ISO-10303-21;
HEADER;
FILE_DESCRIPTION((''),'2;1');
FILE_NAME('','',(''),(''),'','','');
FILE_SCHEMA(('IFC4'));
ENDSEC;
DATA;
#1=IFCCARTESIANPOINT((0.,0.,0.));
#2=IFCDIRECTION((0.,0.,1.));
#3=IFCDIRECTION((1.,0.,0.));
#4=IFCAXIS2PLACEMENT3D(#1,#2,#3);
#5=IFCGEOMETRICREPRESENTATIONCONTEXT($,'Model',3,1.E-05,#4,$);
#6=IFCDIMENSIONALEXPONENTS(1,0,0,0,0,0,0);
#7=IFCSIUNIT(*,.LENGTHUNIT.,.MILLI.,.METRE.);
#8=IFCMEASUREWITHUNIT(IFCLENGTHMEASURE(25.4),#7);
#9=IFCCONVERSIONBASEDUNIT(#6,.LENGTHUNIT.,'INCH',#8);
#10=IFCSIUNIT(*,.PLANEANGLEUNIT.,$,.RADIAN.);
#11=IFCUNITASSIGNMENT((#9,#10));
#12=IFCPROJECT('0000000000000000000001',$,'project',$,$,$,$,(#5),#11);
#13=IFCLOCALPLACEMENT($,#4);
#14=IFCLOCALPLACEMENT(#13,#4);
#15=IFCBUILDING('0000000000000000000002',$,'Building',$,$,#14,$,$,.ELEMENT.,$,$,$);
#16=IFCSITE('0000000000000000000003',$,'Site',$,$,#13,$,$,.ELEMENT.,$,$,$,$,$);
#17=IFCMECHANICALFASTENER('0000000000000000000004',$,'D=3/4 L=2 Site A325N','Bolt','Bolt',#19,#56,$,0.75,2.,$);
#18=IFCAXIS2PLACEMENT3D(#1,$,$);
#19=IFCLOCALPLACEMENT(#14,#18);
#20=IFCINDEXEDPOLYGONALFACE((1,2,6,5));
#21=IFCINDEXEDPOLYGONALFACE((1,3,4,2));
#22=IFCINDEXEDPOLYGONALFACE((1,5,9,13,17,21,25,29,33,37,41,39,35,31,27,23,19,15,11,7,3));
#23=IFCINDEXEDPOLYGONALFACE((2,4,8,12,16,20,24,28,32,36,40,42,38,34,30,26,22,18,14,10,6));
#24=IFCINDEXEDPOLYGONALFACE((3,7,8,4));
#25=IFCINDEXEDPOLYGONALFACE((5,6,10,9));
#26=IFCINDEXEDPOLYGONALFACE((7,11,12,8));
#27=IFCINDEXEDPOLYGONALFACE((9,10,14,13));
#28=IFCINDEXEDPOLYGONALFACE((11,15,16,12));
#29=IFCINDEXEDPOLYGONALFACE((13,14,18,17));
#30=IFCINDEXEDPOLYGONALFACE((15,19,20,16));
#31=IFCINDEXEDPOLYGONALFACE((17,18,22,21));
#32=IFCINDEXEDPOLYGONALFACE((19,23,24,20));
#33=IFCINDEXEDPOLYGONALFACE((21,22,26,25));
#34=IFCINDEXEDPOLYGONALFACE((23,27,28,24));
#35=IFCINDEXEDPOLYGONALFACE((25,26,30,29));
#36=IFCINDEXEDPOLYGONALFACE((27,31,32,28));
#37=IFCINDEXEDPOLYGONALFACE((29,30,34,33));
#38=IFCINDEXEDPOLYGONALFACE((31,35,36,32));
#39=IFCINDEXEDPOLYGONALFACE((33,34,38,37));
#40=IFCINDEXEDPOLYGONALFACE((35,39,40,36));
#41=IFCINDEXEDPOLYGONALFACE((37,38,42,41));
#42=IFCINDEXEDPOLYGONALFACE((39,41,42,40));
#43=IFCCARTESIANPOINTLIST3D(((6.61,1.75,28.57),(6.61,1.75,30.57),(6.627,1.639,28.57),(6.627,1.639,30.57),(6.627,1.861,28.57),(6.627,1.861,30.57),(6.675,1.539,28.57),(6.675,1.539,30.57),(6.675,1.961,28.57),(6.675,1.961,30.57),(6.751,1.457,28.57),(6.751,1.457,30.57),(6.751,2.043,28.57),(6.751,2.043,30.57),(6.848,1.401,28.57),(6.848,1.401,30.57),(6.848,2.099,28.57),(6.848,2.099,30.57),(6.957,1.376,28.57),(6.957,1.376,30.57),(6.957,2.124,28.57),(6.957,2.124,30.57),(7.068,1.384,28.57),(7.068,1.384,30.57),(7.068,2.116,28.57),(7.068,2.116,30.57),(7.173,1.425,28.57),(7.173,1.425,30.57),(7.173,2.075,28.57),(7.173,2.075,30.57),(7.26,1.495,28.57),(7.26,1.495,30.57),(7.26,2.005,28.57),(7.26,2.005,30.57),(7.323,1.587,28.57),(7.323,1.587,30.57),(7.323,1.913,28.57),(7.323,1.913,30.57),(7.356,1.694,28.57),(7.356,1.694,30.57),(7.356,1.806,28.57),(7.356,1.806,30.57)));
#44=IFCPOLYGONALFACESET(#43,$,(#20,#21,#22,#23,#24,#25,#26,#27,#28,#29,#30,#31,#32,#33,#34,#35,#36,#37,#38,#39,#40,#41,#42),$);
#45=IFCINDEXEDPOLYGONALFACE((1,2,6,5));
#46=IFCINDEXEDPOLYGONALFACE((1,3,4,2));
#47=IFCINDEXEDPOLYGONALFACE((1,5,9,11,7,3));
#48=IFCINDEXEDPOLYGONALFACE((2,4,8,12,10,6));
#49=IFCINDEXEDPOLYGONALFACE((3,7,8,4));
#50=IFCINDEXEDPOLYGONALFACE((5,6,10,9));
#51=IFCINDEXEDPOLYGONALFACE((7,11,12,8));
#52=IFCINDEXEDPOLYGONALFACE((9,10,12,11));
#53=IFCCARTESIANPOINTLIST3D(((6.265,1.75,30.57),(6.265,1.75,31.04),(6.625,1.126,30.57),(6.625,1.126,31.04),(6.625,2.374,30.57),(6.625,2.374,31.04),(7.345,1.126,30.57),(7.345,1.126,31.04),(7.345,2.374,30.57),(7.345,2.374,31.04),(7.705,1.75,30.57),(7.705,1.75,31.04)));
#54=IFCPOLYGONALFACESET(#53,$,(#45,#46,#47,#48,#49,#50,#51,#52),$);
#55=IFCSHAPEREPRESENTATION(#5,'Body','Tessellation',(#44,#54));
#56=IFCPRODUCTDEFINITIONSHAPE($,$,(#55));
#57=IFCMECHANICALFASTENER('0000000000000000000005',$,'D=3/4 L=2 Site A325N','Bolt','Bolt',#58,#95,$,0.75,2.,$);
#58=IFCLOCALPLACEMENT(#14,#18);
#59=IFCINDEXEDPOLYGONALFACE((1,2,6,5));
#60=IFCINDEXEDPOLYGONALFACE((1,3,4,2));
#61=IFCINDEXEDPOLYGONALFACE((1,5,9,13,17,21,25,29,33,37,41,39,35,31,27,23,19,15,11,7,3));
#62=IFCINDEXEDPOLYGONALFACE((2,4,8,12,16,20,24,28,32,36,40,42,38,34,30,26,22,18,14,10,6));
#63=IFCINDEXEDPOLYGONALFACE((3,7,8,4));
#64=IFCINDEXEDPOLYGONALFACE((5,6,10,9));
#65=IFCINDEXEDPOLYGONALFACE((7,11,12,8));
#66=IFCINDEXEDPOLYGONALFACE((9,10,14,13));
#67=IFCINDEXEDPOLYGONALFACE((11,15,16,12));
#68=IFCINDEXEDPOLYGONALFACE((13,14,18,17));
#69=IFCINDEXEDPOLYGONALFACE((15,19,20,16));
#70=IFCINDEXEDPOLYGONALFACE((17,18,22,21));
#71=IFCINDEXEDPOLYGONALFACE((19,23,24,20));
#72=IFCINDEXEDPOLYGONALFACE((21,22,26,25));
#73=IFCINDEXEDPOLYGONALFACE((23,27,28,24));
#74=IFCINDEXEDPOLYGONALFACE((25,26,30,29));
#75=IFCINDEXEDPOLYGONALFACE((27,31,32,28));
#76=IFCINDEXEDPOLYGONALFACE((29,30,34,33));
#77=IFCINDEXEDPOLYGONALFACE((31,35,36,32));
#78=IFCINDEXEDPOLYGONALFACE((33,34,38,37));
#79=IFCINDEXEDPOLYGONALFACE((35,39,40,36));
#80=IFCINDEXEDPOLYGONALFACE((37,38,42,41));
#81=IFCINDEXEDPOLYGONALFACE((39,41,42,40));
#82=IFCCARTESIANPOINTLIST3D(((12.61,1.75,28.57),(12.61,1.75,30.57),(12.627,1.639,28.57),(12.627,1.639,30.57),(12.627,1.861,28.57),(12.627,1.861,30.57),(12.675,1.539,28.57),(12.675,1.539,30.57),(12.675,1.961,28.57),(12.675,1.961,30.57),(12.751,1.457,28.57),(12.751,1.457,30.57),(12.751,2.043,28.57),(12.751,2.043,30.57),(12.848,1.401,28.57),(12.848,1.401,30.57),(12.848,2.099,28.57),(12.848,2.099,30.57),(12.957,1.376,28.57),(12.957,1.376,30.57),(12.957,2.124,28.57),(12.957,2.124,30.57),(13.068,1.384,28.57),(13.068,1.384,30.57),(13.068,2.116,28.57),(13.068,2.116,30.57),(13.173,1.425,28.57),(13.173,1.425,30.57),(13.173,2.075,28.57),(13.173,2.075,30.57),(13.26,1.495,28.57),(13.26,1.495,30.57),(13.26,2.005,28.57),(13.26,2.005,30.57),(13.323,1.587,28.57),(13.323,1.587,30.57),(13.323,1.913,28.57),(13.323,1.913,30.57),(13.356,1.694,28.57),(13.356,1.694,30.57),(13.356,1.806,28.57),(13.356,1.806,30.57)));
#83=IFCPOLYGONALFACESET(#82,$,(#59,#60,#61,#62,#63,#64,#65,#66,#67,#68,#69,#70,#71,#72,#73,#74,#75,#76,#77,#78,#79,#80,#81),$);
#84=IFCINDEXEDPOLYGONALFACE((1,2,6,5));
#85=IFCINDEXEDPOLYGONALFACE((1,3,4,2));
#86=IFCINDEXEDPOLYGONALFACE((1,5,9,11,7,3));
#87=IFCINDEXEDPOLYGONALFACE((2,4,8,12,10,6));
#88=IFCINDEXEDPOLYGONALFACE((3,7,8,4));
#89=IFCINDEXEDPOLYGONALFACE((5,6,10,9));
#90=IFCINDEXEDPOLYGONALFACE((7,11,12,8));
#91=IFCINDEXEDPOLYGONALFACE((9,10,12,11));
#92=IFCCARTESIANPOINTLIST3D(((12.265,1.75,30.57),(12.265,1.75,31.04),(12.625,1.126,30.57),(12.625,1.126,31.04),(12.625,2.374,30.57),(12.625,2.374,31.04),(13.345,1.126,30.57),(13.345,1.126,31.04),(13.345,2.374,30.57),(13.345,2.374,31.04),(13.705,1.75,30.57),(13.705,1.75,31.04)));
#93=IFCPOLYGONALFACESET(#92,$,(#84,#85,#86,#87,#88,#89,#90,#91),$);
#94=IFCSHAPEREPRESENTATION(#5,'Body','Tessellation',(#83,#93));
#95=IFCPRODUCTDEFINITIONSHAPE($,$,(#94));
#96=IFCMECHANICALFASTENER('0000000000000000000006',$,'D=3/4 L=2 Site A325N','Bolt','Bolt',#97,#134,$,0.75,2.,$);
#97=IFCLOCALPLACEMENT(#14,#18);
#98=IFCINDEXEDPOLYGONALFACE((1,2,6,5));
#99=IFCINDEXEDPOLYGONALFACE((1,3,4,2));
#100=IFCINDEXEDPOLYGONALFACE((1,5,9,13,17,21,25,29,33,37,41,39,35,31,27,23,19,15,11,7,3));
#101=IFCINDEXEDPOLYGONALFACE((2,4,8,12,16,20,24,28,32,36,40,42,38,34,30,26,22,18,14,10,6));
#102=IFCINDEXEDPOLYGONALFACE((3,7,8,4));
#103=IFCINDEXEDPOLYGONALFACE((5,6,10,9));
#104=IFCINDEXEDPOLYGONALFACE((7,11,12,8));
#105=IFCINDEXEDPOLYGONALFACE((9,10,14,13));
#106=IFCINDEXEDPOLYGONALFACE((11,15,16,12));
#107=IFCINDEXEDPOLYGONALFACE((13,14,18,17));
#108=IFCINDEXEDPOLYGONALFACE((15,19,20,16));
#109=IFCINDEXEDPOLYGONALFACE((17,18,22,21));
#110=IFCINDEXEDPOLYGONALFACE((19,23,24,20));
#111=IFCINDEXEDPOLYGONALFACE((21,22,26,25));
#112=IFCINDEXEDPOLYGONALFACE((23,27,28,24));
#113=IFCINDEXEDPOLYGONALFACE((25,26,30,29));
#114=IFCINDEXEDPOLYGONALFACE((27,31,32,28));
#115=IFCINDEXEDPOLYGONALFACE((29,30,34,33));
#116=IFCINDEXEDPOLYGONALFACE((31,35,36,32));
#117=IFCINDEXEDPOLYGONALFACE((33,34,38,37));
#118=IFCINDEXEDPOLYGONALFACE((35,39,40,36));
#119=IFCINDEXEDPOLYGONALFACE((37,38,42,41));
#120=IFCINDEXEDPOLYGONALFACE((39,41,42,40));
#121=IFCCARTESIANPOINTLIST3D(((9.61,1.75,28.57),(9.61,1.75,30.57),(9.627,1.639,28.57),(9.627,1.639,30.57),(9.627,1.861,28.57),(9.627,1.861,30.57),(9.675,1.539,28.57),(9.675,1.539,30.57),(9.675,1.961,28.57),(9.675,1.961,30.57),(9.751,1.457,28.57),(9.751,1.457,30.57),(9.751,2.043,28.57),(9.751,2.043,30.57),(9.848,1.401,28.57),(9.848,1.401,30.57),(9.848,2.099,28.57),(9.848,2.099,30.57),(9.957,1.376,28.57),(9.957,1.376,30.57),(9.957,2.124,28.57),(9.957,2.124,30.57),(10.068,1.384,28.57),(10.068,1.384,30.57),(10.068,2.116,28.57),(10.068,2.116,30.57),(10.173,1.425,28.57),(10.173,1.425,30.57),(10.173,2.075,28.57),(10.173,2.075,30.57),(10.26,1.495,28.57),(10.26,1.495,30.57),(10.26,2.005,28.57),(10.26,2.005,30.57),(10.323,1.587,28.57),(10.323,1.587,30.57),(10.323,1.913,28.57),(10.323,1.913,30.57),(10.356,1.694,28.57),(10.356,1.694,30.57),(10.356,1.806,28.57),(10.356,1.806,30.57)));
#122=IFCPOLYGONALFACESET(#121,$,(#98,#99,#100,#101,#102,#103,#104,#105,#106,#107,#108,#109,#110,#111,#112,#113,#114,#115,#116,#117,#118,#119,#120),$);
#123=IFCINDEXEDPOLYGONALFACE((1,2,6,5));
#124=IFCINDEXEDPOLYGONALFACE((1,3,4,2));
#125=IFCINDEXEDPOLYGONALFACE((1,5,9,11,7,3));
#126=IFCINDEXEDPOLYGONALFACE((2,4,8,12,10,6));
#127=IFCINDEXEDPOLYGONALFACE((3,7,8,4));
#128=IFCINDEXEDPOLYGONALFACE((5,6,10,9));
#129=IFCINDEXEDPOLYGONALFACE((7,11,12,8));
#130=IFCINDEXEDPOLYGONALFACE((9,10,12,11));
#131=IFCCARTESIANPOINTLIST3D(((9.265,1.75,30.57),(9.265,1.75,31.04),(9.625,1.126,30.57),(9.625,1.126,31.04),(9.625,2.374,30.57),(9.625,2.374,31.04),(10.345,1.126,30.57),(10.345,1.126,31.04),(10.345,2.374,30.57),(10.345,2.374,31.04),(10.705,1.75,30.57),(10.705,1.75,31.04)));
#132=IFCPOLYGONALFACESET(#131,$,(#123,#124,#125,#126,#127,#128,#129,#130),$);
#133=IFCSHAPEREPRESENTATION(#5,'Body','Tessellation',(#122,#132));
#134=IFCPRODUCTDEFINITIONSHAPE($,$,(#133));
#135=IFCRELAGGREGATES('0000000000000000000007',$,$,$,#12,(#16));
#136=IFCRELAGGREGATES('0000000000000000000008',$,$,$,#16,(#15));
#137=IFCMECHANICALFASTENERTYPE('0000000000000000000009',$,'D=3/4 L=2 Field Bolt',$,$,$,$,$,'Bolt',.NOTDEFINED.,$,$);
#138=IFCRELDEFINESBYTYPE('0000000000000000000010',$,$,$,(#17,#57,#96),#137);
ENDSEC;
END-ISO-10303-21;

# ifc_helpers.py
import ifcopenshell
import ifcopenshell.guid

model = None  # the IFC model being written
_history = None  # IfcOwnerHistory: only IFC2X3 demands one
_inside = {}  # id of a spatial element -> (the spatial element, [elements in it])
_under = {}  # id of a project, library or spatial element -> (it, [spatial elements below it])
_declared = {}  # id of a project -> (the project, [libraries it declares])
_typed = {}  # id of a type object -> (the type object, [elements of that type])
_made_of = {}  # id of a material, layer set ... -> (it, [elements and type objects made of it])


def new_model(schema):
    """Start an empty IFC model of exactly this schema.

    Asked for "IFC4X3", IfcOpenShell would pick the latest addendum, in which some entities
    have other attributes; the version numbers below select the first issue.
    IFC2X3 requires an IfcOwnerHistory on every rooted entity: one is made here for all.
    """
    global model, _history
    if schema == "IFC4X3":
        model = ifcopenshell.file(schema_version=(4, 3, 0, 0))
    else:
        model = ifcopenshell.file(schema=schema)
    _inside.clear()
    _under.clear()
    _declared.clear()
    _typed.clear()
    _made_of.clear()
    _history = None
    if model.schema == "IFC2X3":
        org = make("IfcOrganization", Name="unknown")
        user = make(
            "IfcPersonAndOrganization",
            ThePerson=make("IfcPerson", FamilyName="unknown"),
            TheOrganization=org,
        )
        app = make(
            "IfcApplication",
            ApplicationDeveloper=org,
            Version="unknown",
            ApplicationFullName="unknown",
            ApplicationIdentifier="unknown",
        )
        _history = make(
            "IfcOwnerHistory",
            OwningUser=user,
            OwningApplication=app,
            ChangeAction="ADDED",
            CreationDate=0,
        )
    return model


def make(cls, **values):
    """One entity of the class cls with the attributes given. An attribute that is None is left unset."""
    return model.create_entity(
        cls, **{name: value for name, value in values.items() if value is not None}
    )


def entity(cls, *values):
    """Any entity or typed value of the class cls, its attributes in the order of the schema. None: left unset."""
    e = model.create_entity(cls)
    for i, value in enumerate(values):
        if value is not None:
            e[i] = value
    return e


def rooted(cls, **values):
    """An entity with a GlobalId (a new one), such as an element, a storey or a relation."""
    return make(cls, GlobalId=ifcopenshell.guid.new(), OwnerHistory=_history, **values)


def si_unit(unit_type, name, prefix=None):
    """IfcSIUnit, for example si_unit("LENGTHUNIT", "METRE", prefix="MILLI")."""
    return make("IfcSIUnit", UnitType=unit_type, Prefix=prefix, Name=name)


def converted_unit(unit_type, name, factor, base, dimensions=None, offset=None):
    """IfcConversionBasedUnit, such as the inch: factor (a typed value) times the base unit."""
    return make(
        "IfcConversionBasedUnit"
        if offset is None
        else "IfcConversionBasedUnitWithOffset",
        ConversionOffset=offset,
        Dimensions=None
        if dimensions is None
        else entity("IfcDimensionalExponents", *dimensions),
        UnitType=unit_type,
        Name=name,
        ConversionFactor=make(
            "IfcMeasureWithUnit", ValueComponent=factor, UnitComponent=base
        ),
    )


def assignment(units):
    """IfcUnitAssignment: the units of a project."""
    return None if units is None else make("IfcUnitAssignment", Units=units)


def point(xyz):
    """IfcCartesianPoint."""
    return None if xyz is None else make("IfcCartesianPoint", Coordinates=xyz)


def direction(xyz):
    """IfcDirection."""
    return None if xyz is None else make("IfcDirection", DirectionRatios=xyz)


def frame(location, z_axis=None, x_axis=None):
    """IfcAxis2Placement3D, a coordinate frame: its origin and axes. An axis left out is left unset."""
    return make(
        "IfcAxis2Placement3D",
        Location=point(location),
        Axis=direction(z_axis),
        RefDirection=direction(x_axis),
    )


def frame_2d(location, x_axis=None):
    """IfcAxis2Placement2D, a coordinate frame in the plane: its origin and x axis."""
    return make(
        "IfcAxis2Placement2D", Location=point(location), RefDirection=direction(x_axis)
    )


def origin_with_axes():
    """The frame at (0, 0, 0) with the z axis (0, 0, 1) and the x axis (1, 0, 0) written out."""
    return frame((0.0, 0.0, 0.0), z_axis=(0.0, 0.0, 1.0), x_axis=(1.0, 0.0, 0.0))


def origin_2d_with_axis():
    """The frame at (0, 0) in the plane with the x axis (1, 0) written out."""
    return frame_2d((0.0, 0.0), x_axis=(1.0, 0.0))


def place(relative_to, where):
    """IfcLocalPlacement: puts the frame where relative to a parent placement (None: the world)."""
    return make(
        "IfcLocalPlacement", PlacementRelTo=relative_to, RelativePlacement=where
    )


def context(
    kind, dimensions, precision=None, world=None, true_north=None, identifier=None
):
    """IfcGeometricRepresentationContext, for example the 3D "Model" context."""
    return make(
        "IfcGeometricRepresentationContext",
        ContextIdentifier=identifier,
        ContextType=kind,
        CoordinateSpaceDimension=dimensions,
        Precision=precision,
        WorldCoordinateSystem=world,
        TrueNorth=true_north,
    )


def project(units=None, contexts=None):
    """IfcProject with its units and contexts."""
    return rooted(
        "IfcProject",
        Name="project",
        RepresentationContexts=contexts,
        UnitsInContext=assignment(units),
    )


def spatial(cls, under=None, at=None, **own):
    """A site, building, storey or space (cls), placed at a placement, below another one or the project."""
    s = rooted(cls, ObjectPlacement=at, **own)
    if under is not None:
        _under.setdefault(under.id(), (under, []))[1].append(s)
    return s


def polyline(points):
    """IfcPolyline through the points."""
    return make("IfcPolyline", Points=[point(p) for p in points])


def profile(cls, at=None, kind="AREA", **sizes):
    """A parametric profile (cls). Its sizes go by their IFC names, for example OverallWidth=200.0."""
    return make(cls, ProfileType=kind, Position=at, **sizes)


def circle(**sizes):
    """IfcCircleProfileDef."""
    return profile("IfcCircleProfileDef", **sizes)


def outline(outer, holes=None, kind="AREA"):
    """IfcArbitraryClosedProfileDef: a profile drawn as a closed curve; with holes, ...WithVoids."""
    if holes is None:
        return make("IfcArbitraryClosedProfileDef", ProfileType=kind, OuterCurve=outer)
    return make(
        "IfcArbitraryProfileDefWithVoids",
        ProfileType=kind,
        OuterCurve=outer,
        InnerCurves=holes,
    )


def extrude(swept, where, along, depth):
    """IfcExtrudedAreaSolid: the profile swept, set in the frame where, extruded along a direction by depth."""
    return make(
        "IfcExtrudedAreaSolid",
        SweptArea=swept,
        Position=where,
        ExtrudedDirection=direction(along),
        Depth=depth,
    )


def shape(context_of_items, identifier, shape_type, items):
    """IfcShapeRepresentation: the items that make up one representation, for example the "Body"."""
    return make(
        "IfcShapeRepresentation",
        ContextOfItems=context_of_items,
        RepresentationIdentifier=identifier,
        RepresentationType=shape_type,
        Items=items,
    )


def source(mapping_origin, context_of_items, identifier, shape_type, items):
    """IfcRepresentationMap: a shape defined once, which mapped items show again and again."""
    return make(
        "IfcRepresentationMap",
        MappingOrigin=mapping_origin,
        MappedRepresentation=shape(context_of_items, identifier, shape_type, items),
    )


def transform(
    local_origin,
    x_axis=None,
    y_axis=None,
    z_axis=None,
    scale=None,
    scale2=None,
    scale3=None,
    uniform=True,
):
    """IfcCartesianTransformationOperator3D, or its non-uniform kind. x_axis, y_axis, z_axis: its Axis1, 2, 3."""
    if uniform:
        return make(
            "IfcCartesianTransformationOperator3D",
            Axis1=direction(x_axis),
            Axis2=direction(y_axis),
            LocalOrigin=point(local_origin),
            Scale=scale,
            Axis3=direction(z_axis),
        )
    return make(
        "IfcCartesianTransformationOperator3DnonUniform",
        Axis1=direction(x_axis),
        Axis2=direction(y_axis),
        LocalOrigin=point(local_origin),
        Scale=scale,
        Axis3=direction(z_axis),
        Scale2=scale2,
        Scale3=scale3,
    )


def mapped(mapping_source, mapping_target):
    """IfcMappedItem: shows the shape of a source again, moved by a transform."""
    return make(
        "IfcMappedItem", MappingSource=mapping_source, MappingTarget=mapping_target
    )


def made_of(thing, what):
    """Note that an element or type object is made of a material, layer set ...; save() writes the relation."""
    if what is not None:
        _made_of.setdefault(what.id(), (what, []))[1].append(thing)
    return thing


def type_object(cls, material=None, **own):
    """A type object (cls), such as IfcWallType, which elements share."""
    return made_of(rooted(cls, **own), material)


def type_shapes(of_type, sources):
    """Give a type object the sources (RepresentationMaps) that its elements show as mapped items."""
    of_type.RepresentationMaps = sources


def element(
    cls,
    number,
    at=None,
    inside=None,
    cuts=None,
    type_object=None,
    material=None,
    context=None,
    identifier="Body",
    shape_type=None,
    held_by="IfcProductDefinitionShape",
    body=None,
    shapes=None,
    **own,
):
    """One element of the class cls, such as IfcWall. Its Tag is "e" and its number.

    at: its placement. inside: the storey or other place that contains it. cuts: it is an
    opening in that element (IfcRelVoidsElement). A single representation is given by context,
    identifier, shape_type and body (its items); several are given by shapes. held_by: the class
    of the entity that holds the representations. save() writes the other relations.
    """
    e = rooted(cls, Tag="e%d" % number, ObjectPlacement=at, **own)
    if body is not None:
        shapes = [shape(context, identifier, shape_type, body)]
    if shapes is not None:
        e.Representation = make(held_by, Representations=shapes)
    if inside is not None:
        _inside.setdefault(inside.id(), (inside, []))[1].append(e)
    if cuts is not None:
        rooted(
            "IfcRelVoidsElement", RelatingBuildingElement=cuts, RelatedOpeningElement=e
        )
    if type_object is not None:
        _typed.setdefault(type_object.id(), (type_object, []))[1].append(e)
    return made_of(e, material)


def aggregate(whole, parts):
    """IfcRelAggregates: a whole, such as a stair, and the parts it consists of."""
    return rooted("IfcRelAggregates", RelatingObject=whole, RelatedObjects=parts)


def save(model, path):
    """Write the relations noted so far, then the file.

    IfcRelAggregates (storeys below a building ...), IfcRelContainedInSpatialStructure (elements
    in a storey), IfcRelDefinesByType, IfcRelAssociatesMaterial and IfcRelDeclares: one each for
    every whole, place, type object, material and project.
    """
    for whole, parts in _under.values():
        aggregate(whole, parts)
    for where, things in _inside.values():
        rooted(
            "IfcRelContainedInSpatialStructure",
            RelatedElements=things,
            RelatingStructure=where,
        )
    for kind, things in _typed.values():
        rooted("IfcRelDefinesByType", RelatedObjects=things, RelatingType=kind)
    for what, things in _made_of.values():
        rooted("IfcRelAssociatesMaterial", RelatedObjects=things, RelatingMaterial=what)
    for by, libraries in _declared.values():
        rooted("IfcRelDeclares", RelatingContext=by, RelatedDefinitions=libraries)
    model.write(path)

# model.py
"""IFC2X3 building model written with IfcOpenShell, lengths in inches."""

from ifc_helpers import new_model, entity, si_unit, converted_unit, frame, origin_with_axes, origin_2d_with_axis, place, context, project, spatial, polyline, circle, outline, extrude, source, transform, mapped, type_object, type_shapes, element, save


model = new_model("IFC2X3")

# Units and contexts
model_context = context("Model", 3, precision=1e-05, world=origin_with_axes())
ifc_project = project(units=[converted_unit("LENGTHUNIT", "INCH", entity("IfcLengthMeasure", 25.4), si_unit("LENGTHUNIT", "METRE", prefix="MILLI"), dimensions=[1, 0, 0, 0, 0, 0, 0]), si_unit("PLANEANGLEUNIT", "RADIAN")], contexts=[model_context])

# Site, building
site_placement = place(None, origin_with_axes())
site = spatial("IfcSite", under=ifc_project, at=site_placement, Name="Site", CompositionType="ELEMENT")
building_placement = place(site_placement, origin_with_axes())
building = spatial("IfcBuilding", under=site, at=building_placement, Name="Building", CompositionType="ELEMENT")

# Mechanical fasteners
placement_1 = place(building_placement, frame((0.0, 0.0, 46.0), z_axis=(0.0, 0.0, 1.0), x_axis=(1.0, 0.0, 0.0)))
mechanical_fastener_type_1 = type_object("IfcMechanicalFastenerType", Name="D=3/4 L=2 Field Bolt", ElementType="Bolt")
shared_shape_1 = source(origin_with_axes(), model_context, "Body", "SweptSolid", [
    extrude(circle(Radius=0.375, at=origin_2d_with_axis()), frame((0.0, 0.0, 0.0), z_axis=(1.0, 0.0, 0.0), x_axis=(0.0, 1.0, 0.0)), (0.0, 0.0, 1.0), 2.0),
    extrude(outline(polyline([(-0.72, 0.0), (-0.36, 0.624), (0.36, 0.624), (0.72, 0.0), (0.36, -0.624), (-0.36, -0.624), (-0.72, 0.0)])), frame((0.0, 0.0, 0.0), z_axis=(1.0, 0.0, 0.0), x_axis=(0.0, 1.0, 0.0)), (0.0, 0.0, -1.0), 0.47),
])
type_shapes(mechanical_fastener_type_1, [shared_shape_1])
placement_2 = place(placement_1, frame((6.985, 1.75, -15.43), z_axis=(0.0, 1.0, 0.0), x_axis=(0.0, 0.0, -1.0)))
for number, where, z_axis, x_axis, name in (
    (1, (0.0, 0.0, 0.0), (0.0, 0.0, 1.0), (1.0, 0.0, 0.0), "D=3/4 L=2 Site A325N"),
    (2, (0.0, -6.0, 0.0), (0.0, 0.0, 1.0), (1.0, 0.0, 0.0), "D=3/4 L=2 Site A325N"),
    (3, (0.0, -3.0, 0.0), (0.0, 0.0, 1.0), (1.0, 0.0, 0.0), "D=3/4 L=2 Site A325N"),
):
    element("IfcMechanicalFastener", number, at=place(placement_2, frame(where, z_axis=z_axis, x_axis=x_axis)), type_object=mechanical_fastener_type_1, Name=name, Description="Bolt", ObjectType="Bolt", NominalDiameter=0.75, NominalLength=2.0, context=model_context, shape_type="MappedRepresentation", body=[
        mapped(shared_shape_1, transform((0.0, 0.0, 0.0), scale=1.0)),
    ])

save(model, "model.ifc")
